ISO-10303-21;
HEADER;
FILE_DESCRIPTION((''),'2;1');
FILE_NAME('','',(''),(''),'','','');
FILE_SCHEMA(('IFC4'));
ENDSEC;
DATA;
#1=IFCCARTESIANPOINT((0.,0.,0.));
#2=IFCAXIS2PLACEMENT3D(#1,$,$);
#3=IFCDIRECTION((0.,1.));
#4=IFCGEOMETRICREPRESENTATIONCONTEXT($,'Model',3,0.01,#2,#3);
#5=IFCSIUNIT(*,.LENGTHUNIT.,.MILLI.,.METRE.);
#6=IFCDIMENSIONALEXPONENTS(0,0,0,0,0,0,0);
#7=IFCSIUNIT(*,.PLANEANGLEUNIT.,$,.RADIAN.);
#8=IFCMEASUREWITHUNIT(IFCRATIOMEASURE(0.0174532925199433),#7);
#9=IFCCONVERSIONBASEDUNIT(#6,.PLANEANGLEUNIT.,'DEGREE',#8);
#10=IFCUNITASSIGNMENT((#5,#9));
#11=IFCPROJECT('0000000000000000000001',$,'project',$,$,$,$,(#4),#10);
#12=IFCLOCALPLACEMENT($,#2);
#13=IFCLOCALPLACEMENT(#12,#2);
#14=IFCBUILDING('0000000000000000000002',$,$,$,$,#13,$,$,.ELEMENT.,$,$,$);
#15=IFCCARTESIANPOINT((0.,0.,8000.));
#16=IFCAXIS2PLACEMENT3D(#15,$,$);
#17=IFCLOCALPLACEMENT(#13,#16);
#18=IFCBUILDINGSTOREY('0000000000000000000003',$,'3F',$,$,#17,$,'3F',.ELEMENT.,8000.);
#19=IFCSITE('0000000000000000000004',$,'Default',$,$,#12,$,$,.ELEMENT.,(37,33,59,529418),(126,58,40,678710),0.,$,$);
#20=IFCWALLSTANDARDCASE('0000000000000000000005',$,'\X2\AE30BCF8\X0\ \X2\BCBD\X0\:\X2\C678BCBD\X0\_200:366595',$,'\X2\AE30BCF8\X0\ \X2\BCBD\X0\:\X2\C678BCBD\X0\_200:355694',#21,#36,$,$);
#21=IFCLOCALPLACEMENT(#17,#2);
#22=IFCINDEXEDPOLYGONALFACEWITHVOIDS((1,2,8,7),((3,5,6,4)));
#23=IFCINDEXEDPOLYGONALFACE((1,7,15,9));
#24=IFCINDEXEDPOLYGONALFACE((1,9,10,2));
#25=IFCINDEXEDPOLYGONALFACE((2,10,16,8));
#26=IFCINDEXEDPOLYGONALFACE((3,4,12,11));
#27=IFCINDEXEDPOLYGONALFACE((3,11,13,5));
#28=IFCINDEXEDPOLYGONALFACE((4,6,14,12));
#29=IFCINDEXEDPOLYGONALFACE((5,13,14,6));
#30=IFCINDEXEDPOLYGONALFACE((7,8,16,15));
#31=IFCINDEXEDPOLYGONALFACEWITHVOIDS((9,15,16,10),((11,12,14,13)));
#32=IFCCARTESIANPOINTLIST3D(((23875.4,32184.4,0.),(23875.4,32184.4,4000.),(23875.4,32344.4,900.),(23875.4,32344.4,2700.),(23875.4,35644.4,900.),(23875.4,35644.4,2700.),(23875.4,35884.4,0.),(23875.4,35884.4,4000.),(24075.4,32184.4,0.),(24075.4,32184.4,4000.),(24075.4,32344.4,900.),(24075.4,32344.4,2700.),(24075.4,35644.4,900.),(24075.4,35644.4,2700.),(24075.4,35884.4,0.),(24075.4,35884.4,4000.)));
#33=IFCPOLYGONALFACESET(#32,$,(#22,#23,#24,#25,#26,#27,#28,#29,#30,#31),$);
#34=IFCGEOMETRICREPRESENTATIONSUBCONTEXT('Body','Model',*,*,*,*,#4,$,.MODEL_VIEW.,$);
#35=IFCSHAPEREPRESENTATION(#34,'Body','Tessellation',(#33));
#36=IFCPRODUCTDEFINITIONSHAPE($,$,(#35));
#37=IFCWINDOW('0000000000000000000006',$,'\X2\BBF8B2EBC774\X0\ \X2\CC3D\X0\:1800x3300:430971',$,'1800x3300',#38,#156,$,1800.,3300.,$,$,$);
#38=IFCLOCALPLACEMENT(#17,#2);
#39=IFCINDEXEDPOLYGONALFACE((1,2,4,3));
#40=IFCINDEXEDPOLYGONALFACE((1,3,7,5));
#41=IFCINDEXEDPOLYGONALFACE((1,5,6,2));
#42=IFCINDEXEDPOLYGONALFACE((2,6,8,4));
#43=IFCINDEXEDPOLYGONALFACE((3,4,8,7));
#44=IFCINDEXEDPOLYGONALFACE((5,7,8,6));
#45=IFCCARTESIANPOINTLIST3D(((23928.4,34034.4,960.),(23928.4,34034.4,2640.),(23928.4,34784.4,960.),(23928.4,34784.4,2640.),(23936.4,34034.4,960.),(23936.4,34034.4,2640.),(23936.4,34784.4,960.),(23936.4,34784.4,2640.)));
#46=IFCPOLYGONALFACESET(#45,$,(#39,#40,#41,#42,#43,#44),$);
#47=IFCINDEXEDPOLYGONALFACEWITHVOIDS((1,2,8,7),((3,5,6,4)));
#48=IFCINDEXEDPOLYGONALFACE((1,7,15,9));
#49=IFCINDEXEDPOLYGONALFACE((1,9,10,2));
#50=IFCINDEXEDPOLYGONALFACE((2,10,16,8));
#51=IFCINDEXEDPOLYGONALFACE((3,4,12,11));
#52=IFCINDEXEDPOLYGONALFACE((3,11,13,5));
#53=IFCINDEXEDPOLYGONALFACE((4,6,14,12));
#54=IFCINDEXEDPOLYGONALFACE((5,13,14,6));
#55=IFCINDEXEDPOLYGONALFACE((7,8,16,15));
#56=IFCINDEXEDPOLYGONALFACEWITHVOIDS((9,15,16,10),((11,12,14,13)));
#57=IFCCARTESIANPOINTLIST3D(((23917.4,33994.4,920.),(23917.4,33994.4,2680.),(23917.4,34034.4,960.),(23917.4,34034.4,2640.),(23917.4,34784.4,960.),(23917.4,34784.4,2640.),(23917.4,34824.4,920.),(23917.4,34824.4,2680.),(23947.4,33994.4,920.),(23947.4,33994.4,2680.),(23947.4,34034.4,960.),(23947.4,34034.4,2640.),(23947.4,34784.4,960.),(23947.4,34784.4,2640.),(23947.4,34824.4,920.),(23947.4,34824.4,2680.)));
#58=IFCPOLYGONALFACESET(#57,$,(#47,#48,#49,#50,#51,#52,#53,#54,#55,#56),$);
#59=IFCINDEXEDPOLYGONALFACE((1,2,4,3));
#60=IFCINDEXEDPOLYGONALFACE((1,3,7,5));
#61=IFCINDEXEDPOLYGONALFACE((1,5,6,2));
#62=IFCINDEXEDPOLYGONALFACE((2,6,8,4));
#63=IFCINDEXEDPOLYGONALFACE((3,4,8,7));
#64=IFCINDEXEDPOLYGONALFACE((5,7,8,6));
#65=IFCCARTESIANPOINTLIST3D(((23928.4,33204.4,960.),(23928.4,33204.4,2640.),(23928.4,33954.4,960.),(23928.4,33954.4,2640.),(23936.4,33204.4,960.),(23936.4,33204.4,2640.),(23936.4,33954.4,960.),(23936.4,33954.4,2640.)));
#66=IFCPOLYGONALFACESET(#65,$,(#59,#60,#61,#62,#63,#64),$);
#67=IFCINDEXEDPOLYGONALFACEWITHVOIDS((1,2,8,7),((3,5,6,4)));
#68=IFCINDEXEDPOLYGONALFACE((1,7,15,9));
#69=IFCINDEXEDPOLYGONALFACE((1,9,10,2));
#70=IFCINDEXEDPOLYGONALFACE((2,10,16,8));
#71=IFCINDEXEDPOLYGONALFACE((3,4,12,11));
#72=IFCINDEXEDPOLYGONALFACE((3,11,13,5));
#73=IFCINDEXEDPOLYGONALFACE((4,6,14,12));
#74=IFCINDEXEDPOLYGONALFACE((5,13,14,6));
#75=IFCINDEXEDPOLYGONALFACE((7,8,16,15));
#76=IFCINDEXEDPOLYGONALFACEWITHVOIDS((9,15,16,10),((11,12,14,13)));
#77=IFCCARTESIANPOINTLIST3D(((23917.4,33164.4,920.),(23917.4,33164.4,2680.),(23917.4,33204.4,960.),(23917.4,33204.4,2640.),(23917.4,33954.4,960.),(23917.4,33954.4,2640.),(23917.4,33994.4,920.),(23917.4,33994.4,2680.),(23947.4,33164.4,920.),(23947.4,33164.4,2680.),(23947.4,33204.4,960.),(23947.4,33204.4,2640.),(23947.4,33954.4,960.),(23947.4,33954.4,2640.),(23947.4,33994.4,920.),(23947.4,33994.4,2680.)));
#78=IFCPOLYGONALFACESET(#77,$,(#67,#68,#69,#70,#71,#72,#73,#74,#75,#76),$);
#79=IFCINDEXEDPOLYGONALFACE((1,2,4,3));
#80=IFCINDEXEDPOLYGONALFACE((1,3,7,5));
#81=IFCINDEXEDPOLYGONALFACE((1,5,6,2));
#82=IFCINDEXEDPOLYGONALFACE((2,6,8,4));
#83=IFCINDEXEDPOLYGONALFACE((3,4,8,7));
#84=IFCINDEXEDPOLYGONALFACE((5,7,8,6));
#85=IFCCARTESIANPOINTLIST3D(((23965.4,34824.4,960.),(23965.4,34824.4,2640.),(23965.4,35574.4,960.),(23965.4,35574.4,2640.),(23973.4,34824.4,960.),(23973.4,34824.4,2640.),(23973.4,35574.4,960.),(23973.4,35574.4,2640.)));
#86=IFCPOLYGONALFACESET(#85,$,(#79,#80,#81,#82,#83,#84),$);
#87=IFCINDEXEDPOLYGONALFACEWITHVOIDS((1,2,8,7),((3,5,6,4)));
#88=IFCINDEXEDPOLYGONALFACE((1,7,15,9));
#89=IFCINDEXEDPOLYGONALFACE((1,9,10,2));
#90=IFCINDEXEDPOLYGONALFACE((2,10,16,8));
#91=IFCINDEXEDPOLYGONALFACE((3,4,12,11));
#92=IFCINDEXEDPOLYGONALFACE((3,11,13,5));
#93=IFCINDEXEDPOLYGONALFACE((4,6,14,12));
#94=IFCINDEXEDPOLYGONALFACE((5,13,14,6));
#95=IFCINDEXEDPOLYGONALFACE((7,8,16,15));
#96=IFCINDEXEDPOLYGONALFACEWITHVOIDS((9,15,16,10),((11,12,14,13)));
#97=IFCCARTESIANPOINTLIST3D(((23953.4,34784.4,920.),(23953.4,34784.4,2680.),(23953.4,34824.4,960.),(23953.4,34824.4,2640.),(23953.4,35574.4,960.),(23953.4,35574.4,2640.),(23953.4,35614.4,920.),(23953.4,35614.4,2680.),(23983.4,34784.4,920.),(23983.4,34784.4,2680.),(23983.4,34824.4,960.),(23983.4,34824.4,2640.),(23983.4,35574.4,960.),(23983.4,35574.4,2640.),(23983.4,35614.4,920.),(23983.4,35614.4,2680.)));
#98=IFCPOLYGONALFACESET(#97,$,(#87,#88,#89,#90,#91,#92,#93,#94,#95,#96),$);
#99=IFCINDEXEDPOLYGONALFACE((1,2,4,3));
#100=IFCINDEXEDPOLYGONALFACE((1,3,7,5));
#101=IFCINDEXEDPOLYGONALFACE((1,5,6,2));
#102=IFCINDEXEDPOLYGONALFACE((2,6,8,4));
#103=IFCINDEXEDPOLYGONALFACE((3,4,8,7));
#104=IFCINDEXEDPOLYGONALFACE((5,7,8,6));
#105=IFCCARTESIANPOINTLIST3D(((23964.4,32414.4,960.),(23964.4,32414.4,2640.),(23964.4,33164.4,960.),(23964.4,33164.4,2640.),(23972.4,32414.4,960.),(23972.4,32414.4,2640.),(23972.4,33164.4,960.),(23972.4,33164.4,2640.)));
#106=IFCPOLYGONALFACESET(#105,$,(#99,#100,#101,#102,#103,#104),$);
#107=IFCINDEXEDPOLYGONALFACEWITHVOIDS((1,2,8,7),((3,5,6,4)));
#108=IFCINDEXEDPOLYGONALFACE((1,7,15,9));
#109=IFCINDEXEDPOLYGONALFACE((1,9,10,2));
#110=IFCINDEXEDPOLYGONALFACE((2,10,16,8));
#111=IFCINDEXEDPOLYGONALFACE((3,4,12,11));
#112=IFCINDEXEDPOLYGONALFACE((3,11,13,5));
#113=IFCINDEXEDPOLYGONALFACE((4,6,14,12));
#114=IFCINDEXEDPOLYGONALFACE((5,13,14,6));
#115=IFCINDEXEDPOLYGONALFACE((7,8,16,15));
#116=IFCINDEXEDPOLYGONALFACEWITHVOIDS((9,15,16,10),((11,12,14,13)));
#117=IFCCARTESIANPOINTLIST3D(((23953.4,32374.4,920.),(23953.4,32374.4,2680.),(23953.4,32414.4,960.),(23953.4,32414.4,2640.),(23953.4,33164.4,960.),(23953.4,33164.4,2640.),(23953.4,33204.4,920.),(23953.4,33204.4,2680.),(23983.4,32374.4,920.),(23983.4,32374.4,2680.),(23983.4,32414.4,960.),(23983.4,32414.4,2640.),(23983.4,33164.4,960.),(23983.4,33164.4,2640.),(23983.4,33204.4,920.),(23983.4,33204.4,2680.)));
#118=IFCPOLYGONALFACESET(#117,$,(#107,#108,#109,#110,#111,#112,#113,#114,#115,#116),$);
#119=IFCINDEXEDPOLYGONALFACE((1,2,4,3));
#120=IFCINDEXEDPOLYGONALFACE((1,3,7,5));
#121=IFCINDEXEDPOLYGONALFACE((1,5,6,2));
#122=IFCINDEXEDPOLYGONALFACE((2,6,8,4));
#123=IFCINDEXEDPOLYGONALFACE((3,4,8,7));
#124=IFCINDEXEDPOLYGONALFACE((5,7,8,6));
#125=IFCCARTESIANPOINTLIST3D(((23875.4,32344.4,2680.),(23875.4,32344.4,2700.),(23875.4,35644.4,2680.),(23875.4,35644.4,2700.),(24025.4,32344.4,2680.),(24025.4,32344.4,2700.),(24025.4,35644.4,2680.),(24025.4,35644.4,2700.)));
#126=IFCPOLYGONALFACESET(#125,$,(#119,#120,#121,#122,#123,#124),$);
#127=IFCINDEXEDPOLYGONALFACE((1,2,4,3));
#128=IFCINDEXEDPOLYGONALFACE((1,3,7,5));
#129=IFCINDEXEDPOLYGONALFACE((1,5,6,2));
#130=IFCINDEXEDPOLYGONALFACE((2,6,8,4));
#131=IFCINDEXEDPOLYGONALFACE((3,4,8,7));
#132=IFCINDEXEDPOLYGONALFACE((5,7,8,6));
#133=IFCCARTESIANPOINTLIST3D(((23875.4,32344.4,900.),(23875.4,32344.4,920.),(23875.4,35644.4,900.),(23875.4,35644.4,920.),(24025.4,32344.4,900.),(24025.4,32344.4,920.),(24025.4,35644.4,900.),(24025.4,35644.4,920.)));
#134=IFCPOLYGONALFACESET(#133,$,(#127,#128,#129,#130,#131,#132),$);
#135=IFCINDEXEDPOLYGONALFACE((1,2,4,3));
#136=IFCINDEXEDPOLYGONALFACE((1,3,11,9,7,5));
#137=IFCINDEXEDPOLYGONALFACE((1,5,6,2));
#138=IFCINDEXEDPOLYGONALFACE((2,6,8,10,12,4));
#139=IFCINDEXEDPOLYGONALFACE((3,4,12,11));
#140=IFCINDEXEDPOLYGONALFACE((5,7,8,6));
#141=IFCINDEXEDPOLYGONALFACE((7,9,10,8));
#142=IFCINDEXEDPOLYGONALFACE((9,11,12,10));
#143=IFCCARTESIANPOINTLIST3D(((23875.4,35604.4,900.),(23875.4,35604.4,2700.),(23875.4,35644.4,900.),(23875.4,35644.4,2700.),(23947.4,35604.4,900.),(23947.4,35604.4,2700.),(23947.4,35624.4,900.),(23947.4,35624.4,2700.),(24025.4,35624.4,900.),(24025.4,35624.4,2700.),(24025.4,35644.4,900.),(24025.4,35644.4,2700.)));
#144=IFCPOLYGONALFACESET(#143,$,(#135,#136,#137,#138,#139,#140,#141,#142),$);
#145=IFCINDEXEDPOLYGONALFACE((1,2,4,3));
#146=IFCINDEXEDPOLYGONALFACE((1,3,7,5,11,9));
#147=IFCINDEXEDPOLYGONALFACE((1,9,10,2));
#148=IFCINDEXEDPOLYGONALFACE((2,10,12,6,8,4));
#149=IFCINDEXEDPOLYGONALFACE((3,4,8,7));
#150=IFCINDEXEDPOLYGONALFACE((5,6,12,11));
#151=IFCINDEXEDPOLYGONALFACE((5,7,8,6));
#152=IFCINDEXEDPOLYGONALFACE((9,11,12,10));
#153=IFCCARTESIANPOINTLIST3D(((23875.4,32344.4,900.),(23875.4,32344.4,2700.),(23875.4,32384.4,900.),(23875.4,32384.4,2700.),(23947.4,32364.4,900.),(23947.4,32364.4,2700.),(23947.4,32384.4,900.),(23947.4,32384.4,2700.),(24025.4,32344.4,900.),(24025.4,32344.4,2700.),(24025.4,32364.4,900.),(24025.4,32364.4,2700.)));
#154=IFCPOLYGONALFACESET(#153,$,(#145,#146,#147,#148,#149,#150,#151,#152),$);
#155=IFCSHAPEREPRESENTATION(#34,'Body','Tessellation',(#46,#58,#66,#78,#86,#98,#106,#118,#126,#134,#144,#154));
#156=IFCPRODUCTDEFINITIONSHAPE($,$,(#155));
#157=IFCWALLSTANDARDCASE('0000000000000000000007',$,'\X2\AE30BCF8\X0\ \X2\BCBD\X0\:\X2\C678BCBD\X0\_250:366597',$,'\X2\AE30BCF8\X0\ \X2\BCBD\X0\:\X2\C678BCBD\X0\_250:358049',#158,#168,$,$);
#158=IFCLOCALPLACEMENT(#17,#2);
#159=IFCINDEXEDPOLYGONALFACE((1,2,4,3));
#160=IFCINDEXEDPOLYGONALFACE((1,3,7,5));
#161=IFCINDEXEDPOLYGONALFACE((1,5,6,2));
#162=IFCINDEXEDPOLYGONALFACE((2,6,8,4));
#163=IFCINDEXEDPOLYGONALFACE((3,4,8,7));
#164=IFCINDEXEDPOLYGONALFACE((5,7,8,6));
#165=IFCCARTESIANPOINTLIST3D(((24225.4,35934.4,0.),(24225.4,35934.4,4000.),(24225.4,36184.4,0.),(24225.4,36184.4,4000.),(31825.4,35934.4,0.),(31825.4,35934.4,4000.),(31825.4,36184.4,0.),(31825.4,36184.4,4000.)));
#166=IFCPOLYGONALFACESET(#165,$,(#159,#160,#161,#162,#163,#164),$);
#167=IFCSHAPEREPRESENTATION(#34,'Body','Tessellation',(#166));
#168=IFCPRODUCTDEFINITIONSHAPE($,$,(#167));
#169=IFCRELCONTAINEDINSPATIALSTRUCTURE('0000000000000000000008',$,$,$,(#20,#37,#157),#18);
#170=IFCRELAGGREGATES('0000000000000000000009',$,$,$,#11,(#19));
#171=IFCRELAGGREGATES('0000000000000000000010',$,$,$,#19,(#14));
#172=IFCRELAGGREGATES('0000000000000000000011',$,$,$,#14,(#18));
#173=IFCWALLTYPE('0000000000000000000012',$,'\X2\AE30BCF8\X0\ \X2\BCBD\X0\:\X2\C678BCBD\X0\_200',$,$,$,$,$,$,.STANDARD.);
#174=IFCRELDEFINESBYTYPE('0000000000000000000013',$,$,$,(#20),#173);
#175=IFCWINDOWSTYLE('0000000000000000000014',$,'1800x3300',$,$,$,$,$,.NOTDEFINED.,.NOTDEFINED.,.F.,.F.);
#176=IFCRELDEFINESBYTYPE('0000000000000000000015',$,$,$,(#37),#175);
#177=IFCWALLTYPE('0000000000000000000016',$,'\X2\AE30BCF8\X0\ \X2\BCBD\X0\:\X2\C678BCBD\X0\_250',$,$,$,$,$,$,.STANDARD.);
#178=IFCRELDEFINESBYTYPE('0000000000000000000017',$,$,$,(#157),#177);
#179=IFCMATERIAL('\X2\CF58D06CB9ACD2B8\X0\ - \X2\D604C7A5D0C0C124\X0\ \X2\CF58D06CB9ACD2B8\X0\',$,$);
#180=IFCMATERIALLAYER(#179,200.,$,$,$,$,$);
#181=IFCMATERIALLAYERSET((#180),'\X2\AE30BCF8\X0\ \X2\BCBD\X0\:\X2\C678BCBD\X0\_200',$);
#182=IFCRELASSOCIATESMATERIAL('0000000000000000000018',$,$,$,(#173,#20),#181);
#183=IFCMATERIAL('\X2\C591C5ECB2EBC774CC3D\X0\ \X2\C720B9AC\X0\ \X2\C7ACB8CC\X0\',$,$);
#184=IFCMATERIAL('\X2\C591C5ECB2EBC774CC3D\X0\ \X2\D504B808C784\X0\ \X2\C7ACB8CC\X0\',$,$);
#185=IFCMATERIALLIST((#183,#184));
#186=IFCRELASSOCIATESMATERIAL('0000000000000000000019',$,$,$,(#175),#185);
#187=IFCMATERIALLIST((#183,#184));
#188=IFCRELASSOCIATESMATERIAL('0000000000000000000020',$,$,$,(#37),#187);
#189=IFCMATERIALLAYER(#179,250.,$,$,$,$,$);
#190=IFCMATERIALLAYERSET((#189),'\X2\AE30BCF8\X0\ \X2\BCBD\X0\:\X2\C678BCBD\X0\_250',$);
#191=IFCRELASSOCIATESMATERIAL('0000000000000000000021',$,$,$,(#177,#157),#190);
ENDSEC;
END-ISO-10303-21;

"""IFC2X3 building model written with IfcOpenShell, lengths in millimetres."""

from ifc_helpers import new_model, entity, si_unit, converted_unit, direction, frame, frame_2d, origin, origin_2d_with_axis, place, context, subcontext, project, spatial, polyline, rectangle, outline, extrude, source, transform, mapped, material, material_list, layer, layer_set, layer_usage, type_object, type_shapes, element, fill, save


model = new_model("IFC2X3")

# Units and contexts
model_context = context("Model", 3, precision=0.01, world=origin(), true_north=direction((0.0, 1.0)))
body_context = subcontext(model_context, "Body", "Model", "MODEL_VIEW")
ifc_project = project(units=[si_unit("LENGTHUNIT", "METRE", prefix="MILLI"), converted_unit("PLANEANGLEUNIT", "DEGREE", entity("IfcRatioMeasure", 0.0174532925199433), si_unit("PLANEANGLEUNIT", "RADIAN"), dimensions=[0, 0, 0, 0, 0, 0, 0])], contexts=[model_context])

# Site, building, storey
site_placement = place(None, origin())
site = spatial("IfcSite", under=ifc_project, at=site_placement, Name="Default", CompositionType="ELEMENT", RefLatitude=(37, 33, 59, 529418), RefLongitude=(126, 58, 40, 678710), RefElevation=0.0)
building_placement = place(site_placement, origin())
building = spatial("IfcBuilding", under=site, at=building_placement, CompositionType="ELEMENT")
storey_placement = place(building_placement, frame((0.0, 0.0, 8000.0)))
storey = spatial("IfcBuildingStorey", under=building, at=storey_placement, Name="3F", LongName="3F", CompositionType="ELEMENT", Elevation=8000.0)

# Shared definitions
ifc_material_1 = material(Name="콘크리트 - 현장타설 콘크리트")

# Wall, opening, window
ifc_layer_1 = layer(ifc_material_1, 200.0)
ifc_layer_set_1 = layer_set([ifc_layer_1], Name="기본 벽:외벽_200")
wall_type_1 = type_object("IfcWallType", Name="기본 벽:외벽_200", PredefinedType="STANDARD", material=ifc_layer_set_1)
ifc_material_2 = material(Name="양여닫이창 유리 재료")
ifc_material_3 = material(Name="양여닫이창 프레임 재료")
ifc_material_list_1 = material_list([ifc_material_2, ifc_material_3])
window_style_1 = type_object("IfcWindowStyle", Name="1800x3300", ConstructionType="NOTDEFINED", OperationType="NOTDEFINED", ParameterTakesPrecedence=False, Sizeable=False, material=ifc_material_list_1)
shared_shape_1 = source(origin(), body_context, "Body", "SweptSolid", [
    extrude(rectangle(XDim=8.0, YDim=750.0, at=frame_2d((0.0, 0.0), x_axis=(1.0, 0.0))), frame((2065.0, 143.0, 60.0), z_axis=(0.0, 0.0, 1.0), x_axis=(0.0, 1.0, 0.0)), (0.0, 0.0, 1.0), 1680.0),
    extrude(outline(polyline([(-880.0, -415.0), (880.0, -415.0), (880.0, 415.0), (-880.0, 415.0), (-880.0, -415.0)]), holes=[polyline([(840.0, -375.0), (-840.0, -375.0), (-840.0, 375.0), (840.0, 375.0), (840.0, -375.0)])]), frame((2065.0, 128.0, 900.0), z_axis=(0.0, 1.0, 0.0), x_axis=(0.0, 0.0, -1.0)), (0.0, 0.0, 1.0), 30.0),
    extrude(rectangle(XDim=8.0, YDim=750.0, at=frame_2d((0.0, 0.0), x_axis=(1.0, 0.0))), frame((1235.0, 143.0, 60.0), z_axis=(0.0, 0.0, 1.0), x_axis=(0.0, 1.0, 0.0)), (0.0, 0.0, 1.0), 1680.0),
    extrude(outline(polyline([(-880.0, -415.0), (880.0, -415.0), (880.0, 415.0), (-880.0, 415.0), (-880.0, -415.0)]), holes=[polyline([(840.0, -375.0), (-840.0, -375.0), (-840.0, 375.0), (840.0, 375.0), (840.0, -375.0)])]), frame((1235.0, 128.0, 900.0), z_axis=(0.0, 1.0, 0.0), x_axis=(0.0, 0.0, -1.0)), (0.0, 0.0, 1.0), 30.0),
    extrude(rectangle(XDim=8.0, YDim=750.0, at=frame_2d((0.0, 0.0), x_axis=(1.0, 0.0))), frame((2855.0, 106.0, 60.0), z_axis=(0.0, 0.0, 1.0), x_axis=(0.0, 1.0, 0.0)), (0.0, 0.0, 1.0), 1680.0),
    extrude(outline(polyline([(-880.0, -415.0), (880.0, -415.0), (880.0, 415.0), (-880.0, 415.0), (-880.0, -415.0)]), holes=[polyline([(840.0, -375.0), (-840.0, -375.0), (-840.0, 375.0), (840.0, 375.0), (840.0, -375.0)])]), frame((2855.0, 92.0, 900.0), z_axis=(0.0, 1.0, 0.0), x_axis=(0.0, 0.0, -1.0)), (0.0, 0.0, 1.0), 30.0),
    extrude(rectangle(XDim=8.0, YDim=750.0, at=origin_2d_with_axis()), frame((445.0, 107.0, 60.0), z_axis=(0.0, 0.0, 1.0), x_axis=(0.0, 1.0, 0.0)), (0.0, 0.0, 1.0), 1680.0),
    extrude(outline(polyline([(-880.0, -415.0), (880.0, -415.0), (880.0, 415.0), (-880.0, 415.0), (-880.0, -415.0)]), holes=[polyline([(840.0, -375.0), (-840.0, -375.0), (-840.0, 375.0), (840.0, 375.0), (840.0, -375.0)])]), frame((445.0, 92.0, 900.0), z_axis=(0.0, 1.0, 0.0), x_axis=(0.0, 0.0, -1.0)), (0.0, 0.0, 1.0), 30.0),
    extrude(rectangle(XDim=3300.0, YDim=150.0, at=origin_2d_with_axis()), frame((1650.0, 125.0, 1780.0), z_axis=(0.0, 0.0, 1.0), x_axis=(-1.0, 0.0, 0.0)), (0.0, 0.0, 1.0), 20.0),
    extrude(rectangle(XDim=3300.0, YDim=150.0, at=origin_2d_with_axis()), frame((1650.0, 125.0, 0.0), z_axis=(0.0, 0.0, 1.0), x_axis=(-1.0, 0.0, 0.0)), (0.0, 0.0, 1.0), 20.0),
    extrude(outline(polyline([(-74.0, -20.0), (-2.0, -20.0), (-2.0, 0.0), (76.0, 0.0), (76.0, 20.0), (-74.0, 20.0), (-74.0, -20.0)])), frame((3280.0, 126.0, 0.0), z_axis=(0.0, 0.0, 1.0), x_axis=(0.0, -1.0, 0.0)), (0.0, 0.0, 1.0), 1800.0),
    extrude(outline(polyline([(-20.0, -74.0), (20.0, -74.0), (20.0, 76.0), (0.0, 76.0), (0.0, -2.0), (-20.0, -2.0), (-20.0, -74.0)])), frame((20.0, 126.0, 0.0), z_axis=(0.0, 0.0, 1.0), x_axis=(-1.0, 0.0, 0.0)), (0.0, 0.0, 1.0), 1800.0),
])
type_shapes(window_style_1, [shared_shape_1])
ifc_layer_usage_1 = layer_usage(ifc_layer_set_1, "AXIS2", "NEGATIVE", 100.0)
wall_1_placement = place(storey_placement, frame((23975.4, 32184.4, 0.0), z_axis=(0.0, 0.0, 1.0), x_axis=(0.0, 1.0, 0.0)))
wall_1 = element("IfcWallStandardCase", 1, at=wall_1_placement, inside=storey, type_object=wall_type_1, material=ifc_layer_usage_1, Name="기본 벽:외벽_200:366595", ObjectType="기본 벽:외벽_200:355694", context=body_context, shape_type="SweptSolid", body=[
    extrude(rectangle(XDim=3700.0, YDim=200.0, at=frame_2d((1850.0, 0.0), x_axis=(-1.0, 0.0))), origin(), (0.0, 0.0, 1.0), 4000.0),
])
opening_1_placement = place(wall_1_placement, frame((160.0, -100.0, 900.0)))
opening_1 = element("IfcOpeningElement", 2, at=opening_1_placement, cuts=wall_1, ObjectType="Opening", context=body_context, shape_type="SweptSolid", body=[
    extrude(rectangle(XDim=1800.0, YDim=3300.0, at=frame_2d((900.0, 1650.0), x_axis=(1.0, 0.0))), frame((0.0, 0.0, 0.0), z_axis=(0.0, 1.0, 0.0), x_axis=(0.0, 0.0, 1.0)), (0.0, 0.0, 1.0), 200.0),
])
ifc_material_list_2 = material_list([ifc_material_2, ifc_material_3])
window_1_placement = place(opening_1_placement, origin())
window_1 = element("IfcWindow", 3, at=window_1_placement, inside=storey, type_object=window_style_1, material=ifc_material_list_2, Name="미닫이 창:1800x3300:430971", ObjectType="1800x3300", OverallHeight=1800.0, OverallWidth=3300.0, context=body_context, shape_type="MappedRepresentation", body=[
    mapped(shared_shape_1, transform((0.0, 0.0, 0.0), scale=1.0)),
])
fill(opening_1, window_1)

# Wall
ifc_layer_2 = layer(ifc_material_1, 250.0)
ifc_layer_set_2 = layer_set([ifc_layer_2], Name="기본 벽:외벽_250")
ifc_layer_usage_2 = layer_usage(ifc_layer_set_2, "AXIS2", "NEGATIVE", 125.0)
wall_type_2 = type_object("IfcWallType", Name="기본 벽:외벽_250", PredefinedType="STANDARD", material=ifc_layer_set_2)
wall_2_placement = place(storey_placement, frame((24225.4, 36059.4, 0.0)))
element("IfcWallStandardCase", 4, at=wall_2_placement, inside=storey, type_object=wall_type_2, material=ifc_layer_usage_2, Name="기본 벽:외벽_250:366597", ObjectType="기본 벽:외벽_250:358049", context=body_context, shape_type="SweptSolid", body=[
    extrude(rectangle(XDim=7600.0, YDim=250.0, at=frame_2d((3800.0, 0.0), x_axis=(-1.0, 0.0))), origin(), (0.0, 0.0, 1.0), 4000.0),
])

save(model, "model.ifc")
